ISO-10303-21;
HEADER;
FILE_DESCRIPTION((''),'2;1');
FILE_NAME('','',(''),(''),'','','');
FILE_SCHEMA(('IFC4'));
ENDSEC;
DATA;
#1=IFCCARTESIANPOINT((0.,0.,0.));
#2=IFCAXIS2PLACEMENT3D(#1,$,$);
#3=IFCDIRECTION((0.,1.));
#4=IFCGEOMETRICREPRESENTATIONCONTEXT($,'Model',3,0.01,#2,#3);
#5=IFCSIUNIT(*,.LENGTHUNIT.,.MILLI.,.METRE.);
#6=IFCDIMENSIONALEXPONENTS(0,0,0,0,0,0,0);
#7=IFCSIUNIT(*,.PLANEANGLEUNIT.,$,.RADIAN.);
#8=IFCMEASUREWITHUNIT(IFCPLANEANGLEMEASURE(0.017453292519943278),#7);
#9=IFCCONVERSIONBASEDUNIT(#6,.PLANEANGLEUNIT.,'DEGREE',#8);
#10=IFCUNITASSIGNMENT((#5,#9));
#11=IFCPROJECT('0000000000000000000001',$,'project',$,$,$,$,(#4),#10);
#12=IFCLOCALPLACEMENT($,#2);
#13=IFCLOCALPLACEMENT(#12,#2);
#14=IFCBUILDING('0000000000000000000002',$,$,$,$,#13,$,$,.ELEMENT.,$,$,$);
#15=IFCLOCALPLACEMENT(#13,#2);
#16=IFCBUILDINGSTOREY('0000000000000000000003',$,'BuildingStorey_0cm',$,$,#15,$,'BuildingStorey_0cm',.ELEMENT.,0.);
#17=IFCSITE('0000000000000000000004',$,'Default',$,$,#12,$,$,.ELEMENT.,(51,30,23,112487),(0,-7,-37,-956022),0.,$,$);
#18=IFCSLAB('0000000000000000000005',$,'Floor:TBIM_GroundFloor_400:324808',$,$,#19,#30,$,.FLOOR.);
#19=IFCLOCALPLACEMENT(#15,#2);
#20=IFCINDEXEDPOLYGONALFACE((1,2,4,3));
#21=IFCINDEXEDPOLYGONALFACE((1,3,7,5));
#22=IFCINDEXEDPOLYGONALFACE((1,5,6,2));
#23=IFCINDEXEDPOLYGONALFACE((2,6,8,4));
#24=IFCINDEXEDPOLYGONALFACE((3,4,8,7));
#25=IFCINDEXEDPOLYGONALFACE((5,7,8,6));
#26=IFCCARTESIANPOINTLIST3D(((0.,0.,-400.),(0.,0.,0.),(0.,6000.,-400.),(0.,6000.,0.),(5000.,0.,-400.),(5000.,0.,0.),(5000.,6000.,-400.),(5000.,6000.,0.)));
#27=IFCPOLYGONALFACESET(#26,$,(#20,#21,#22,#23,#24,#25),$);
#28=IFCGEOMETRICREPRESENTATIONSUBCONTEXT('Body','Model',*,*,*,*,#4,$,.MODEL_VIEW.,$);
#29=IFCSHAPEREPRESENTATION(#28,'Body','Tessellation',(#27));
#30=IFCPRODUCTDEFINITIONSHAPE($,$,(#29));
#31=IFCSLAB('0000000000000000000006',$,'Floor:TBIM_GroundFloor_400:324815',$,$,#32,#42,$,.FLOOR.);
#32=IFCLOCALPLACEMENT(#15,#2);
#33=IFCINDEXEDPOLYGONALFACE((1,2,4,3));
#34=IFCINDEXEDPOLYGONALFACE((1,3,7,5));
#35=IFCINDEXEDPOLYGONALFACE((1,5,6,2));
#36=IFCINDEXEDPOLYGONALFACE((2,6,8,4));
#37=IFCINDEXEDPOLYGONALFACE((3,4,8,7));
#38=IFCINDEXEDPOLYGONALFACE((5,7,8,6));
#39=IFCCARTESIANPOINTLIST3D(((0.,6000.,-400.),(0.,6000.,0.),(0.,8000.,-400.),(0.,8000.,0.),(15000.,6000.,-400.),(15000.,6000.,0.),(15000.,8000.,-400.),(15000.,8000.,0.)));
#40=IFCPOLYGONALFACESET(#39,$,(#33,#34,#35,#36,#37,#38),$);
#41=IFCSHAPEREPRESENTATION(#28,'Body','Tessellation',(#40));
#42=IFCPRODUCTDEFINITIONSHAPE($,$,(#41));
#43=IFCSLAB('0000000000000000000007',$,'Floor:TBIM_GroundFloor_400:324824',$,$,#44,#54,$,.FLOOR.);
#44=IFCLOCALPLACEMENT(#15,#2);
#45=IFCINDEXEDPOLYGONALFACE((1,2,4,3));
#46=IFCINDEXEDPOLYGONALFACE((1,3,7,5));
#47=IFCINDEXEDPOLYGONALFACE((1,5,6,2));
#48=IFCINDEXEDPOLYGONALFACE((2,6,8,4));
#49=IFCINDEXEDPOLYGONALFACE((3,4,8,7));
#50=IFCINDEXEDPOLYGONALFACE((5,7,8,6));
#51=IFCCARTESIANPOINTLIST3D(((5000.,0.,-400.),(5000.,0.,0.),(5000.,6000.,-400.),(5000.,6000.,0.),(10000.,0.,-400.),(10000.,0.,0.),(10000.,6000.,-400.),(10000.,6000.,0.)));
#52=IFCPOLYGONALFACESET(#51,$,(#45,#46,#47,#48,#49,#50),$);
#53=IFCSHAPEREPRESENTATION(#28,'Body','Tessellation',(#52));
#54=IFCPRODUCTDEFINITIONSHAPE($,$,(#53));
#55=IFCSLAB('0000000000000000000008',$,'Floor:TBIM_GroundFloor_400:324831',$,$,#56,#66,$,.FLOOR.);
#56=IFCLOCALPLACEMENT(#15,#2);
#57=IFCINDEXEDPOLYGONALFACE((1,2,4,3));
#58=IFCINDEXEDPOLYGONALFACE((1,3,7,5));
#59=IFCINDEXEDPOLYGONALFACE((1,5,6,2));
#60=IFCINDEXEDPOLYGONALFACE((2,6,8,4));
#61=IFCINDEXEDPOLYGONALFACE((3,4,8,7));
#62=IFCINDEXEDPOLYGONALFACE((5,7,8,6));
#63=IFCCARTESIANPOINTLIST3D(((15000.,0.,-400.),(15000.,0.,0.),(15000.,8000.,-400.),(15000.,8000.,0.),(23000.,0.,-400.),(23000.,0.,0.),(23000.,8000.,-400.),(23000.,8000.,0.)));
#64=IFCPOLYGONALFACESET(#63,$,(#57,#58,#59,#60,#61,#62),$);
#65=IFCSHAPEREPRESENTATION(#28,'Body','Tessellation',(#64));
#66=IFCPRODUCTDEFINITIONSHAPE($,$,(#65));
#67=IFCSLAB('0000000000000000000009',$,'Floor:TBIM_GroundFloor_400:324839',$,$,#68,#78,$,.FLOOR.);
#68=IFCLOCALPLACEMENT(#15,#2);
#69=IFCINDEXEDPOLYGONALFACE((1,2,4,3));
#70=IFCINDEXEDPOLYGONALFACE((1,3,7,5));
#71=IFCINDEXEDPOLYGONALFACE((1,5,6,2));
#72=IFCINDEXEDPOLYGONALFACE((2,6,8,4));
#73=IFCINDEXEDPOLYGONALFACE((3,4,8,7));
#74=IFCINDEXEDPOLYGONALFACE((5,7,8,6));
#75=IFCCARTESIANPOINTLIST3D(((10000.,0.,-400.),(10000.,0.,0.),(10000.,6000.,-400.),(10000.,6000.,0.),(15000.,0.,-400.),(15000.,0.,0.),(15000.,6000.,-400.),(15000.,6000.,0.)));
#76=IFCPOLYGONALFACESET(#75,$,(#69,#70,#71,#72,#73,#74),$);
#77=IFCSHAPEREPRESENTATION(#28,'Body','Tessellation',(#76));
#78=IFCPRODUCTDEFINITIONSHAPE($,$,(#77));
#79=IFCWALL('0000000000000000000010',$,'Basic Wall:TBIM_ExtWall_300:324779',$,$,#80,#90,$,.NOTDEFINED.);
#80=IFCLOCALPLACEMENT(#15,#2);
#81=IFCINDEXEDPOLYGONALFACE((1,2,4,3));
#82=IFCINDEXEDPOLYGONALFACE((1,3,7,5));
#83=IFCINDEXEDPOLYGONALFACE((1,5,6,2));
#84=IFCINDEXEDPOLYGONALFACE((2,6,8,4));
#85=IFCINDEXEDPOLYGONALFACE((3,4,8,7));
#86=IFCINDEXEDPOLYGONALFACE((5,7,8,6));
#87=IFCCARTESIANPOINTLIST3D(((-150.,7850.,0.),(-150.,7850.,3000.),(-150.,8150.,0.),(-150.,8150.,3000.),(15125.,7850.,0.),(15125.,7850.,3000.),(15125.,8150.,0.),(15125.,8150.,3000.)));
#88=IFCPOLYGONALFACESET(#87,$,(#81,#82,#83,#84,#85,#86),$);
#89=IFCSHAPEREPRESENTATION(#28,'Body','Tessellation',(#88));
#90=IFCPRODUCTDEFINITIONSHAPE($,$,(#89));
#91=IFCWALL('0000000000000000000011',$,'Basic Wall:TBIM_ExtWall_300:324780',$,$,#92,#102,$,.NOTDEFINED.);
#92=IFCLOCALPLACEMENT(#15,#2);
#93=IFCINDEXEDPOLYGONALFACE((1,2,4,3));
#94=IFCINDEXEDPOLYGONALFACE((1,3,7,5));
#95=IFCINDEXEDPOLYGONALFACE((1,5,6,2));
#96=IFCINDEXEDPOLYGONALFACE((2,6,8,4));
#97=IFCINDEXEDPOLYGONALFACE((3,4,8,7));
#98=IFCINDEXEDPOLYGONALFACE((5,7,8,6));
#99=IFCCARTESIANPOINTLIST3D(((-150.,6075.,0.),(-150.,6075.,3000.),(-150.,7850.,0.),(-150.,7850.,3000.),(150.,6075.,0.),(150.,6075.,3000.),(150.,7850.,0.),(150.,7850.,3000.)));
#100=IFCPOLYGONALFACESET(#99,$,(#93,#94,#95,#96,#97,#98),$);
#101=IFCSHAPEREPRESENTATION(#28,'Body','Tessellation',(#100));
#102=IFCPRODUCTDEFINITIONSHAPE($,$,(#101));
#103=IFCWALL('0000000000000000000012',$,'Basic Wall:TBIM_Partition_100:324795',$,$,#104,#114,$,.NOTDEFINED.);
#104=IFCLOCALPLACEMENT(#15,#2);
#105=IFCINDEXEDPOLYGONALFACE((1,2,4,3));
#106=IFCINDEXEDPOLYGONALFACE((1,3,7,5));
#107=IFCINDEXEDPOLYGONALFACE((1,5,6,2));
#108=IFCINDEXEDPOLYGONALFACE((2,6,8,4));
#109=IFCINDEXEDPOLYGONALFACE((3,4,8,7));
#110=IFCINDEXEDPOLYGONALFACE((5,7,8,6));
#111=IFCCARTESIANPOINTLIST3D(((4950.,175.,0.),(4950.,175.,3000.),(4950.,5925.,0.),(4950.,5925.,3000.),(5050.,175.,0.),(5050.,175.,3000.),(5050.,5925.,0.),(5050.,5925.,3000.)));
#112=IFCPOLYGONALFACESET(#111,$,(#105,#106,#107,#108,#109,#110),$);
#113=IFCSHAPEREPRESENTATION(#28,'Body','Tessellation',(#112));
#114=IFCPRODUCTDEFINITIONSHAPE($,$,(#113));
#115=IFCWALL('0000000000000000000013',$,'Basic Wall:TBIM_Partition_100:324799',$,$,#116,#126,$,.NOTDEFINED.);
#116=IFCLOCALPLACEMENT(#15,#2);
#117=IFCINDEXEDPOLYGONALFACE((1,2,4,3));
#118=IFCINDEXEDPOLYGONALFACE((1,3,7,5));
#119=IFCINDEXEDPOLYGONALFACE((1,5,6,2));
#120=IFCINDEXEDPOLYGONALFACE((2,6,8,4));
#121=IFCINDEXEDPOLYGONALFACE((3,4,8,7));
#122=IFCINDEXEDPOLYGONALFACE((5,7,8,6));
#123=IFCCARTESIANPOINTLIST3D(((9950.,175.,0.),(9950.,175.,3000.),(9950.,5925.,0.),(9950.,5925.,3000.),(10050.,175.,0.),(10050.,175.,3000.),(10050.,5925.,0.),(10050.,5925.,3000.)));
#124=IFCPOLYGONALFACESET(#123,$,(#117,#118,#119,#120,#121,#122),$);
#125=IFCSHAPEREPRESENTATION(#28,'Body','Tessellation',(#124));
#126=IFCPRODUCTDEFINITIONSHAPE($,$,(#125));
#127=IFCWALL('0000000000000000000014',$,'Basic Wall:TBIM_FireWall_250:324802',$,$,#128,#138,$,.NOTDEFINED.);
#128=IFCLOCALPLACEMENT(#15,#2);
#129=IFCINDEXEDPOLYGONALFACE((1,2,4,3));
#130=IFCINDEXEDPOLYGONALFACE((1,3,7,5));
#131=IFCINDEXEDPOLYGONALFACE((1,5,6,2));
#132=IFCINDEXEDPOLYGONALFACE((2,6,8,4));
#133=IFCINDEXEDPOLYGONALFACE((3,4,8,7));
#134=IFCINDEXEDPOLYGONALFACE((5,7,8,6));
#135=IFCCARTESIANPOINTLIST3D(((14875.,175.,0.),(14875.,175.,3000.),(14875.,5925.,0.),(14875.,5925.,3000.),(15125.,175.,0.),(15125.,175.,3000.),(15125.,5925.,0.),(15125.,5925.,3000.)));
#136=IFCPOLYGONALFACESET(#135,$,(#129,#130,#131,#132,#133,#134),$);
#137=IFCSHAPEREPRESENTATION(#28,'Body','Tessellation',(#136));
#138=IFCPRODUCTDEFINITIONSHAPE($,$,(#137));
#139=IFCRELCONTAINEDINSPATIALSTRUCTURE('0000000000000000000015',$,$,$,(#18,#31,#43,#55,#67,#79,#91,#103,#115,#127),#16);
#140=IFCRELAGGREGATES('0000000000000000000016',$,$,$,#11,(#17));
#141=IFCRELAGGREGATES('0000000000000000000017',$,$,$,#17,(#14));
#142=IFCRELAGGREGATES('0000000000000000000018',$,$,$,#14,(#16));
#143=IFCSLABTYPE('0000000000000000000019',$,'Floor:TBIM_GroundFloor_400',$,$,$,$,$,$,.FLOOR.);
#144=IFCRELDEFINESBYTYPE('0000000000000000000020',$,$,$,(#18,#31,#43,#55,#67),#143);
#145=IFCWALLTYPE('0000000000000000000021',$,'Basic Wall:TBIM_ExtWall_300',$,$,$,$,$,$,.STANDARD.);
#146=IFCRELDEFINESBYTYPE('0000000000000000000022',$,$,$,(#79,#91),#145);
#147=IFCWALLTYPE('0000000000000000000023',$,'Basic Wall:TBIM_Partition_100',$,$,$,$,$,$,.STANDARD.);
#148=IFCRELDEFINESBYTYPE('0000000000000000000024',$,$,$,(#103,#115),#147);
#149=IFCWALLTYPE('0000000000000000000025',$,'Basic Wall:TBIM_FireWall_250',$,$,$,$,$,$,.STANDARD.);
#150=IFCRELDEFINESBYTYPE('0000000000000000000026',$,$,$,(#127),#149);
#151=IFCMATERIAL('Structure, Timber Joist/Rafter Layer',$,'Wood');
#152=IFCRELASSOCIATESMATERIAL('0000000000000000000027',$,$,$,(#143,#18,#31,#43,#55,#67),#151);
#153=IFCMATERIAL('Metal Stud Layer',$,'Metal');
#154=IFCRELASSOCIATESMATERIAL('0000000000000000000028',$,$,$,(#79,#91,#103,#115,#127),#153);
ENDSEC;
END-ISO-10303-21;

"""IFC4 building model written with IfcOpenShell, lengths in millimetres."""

from ifc_helpers import new_model, entity, si_unit, converted_unit, direction, frame, origin, place, context, subcontext, project, spatial, indexed_curve, outline, extrude, material, type_object, element, save


model = new_model("IFC4")

# Units and contexts
model_context = context("Model", 3, precision=0.01, world=origin(), true_north=direction((0.0, 1.0)))
body_context = subcontext(model_context, "Body", "Model", "MODEL_VIEW")
ifc_project = project(units=[si_unit("LENGTHUNIT", "METRE", prefix="MILLI"), converted_unit("PLANEANGLEUNIT", "DEGREE", entity("IfcPlaneAngleMeasure", 0.017453292519943278), si_unit("PLANEANGLEUNIT", "RADIAN"), dimensions=[0, 0, 0, 0, 0, 0, 0])], contexts=[model_context])

# Site, building, storey
site_placement = place(None, origin())
site = spatial("IfcSite", under=ifc_project, at=site_placement, Name="Default", CompositionType="ELEMENT", RefLatitude=(51, 30, 23, 112487), RefLongitude=(0, -7, -37, -956022), RefElevation=0.0)
building_placement = place(site_placement, origin())
building = spatial("IfcBuilding", under=site, at=building_placement, CompositionType="ELEMENT")
storey_placement = place(building_placement, origin())
storey = spatial("IfcBuildingStorey", under=building, at=storey_placement, Name="BuildingStorey_0cm", LongName="BuildingStorey_0cm", CompositionType="ELEMENT", Elevation=0.0)

# Slabs
ifc_material_1 = material(Name="Structure, Timber Joist/Rafter Layer", Category="Wood")
slab_type = type_object("IfcSlabType", Name="Floor:TBIM_GroundFloor_400", PredefinedType="FLOOR", material=ifc_material_1)
slab_1_placement = place(storey_placement, origin())
element("IfcSlab", 1, at=slab_1_placement, inside=storey, type_object=slab_type, material=ifc_material_1, Name="Floor:TBIM_GroundFloor_400:324808", PredefinedType="FLOOR", context=body_context, shape_type="SweptSolid", body=[
    extrude(outline(indexed_curve([(-3000.0, -2500.0), (3000.0, -2500.0), (3000.0, 2500.0), (-3000.0, 2500.0), (-3000.0, -2500.0)], self_intersect=False)), frame((2500.0, 3000.0, 0.0), z_axis=(0.0, 0.0, -1.0), x_axis=(0.0, 1.0, 0.0)), (0.0, 0.0, 1.0), 400.0),
])
slab_2_placement = place(storey_placement, origin())
element("IfcSlab", 2, at=slab_2_placement, inside=storey, type_object=slab_type, material=ifc_material_1, Name="Floor:TBIM_GroundFloor_400:324815", PredefinedType="FLOOR", context=body_context, shape_type="SweptSolid", body=[
    extrude(outline(indexed_curve([(-1000.0, -7500.0), (1000.0, -7500.0), (1000.0, 7500.0), (-1000.0, 7500.0), (-1000.0, -7500.0)], self_intersect=False)), frame((7500.0, 7000.0, 0.0), z_axis=(0.0, 0.0, -1.0), x_axis=(0.0, 1.0, 0.0)), (0.0, 0.0, 1.0), 400.0),
])
slab_3_placement = place(storey_placement, origin())
element("IfcSlab", 3, at=slab_3_placement, inside=storey, type_object=slab_type, material=ifc_material_1, Name="Floor:TBIM_GroundFloor_400:324824", PredefinedType="FLOOR", context=body_context, shape_type="SweptSolid", body=[
    extrude(outline(indexed_curve([(-3000.0, -2500.0), (3000.0, -2500.0), (3000.0, 2500.0), (-3000.0, 2500.0), (-3000.0, -2500.0)], self_intersect=False)), frame((7500.0, 3000.0, 0.0), z_axis=(0.0, 0.0, -1.0), x_axis=(0.0, 1.0, 0.0)), (0.0, 0.0, 1.0), 400.0),
])
slab_4_placement = place(storey_placement, origin())
element("IfcSlab", 4, at=slab_4_placement, inside=storey, type_object=slab_type, material=ifc_material_1, Name="Floor:TBIM_GroundFloor_400:324831", PredefinedType="FLOOR", context=body_context, shape_type="SweptSolid", body=[
    extrude(outline(indexed_curve([(-4000.0, -4000.0), (4000.0, -4000.0), (4000.0, 4000.0), (-4000.0, 4000.0), (-4000.0, -4000.0)], self_intersect=False)), frame((19000.0, 4000.0, 0.0), z_axis=(0.0, 0.0, -1.0), x_axis=(1.0, 0.0, 0.0)), (0.0, 0.0, 1.0), 400.0),
])
slab_5_placement = place(storey_placement, origin())
element("IfcSlab", 5, at=slab_5_placement, inside=storey, type_object=slab_type, material=ifc_material_1, Name="Floor:TBIM_GroundFloor_400:324839", PredefinedType="FLOOR", context=body_context, shape_type="SweptSolid", body=[
    extrude(outline(indexed_curve([(-3000.0, -2500.0), (3000.0, -2500.0), (3000.0, 2500.0), (-3000.0, 2500.0), (-3000.0, -2500.0)], self_intersect=False)), frame((12500.0, 3000.0, 0.0), z_axis=(0.0, 0.0, -1.0), x_axis=(0.0, 1.0, 0.0)), (0.0, 0.0, 1.0), 400.0),
])

# Walls
ifc_material_2 = material(Name="Metal Stud Layer", Category="Metal")
wall_type_1 = type_object("IfcWallType", Name="Basic Wall:TBIM_ExtWall_300", PredefinedType="STANDARD")
wall_1_placement = place(storey_placement, frame((-150.0, 8000.0, 0.0)))
element("IfcWall", 6, at=wall_1_placement, inside=storey, type_object=wall_type_1, material=ifc_material_2, Name="Basic Wall:TBIM_ExtWall_300:324779", PredefinedType="NOTDEFINED", context=body_context, shape_type="SweptSolid", body=[
    extrude(outline(indexed_curve([(15275.0, 150.0), (0.0, 150.0), (0.0, -150.0), (15275.0, -150.0), (15275.0, 150.0)], self_intersect=False)), origin(), (0.0, 0.0, 1.0), 3000.0),
])
wall_2_placement = place(storey_placement, frame((0.0, 7850.0, 0.0), z_axis=(0.0, 0.0, 1.0), x_axis=(0.0, -1.0, 0.0)))
element("IfcWall", 7, at=wall_2_placement, inside=storey, type_object=wall_type_1, material=ifc_material_2, Name="Basic Wall:TBIM_ExtWall_300:324780", PredefinedType="NOTDEFINED", context=body_context, shape_type="SweptSolid", body=[
    extrude(outline(indexed_curve([(1775.0, 150.0), (0.0, 150.0), (0.0, -150.0), (1775.0, -150.0), (1775.0, 150.0)], self_intersect=False)), origin(), (0.0, 0.0, 1.0), 3000.0),
])
wall_type_2 = type_object("IfcWallType", Name="Basic Wall:TBIM_Partition_100", PredefinedType="STANDARD")
wall_3_placement = place(storey_placement, frame((5000.0, 175.0, 0.0), z_axis=(0.0, 0.0, 1.0), x_axis=(0.0, 1.0, 0.0)))
element("IfcWall", 8, at=wall_3_placement, inside=storey, type_object=wall_type_2, material=ifc_material_2, Name="Basic Wall:TBIM_Partition_100:324795", PredefinedType="NOTDEFINED", context=body_context, shape_type="SweptSolid", body=[
    extrude(outline(indexed_curve([(5750.0, 50.0), (0.0, 50.0), (0.0, -50.0), (5750.0, -50.0), (5750.0, 50.0)], self_intersect=False)), origin(), (0.0, 0.0, 1.0), 3000.0),
])
wall_4_placement = place(storey_placement, frame((10000.0, 175.0, 0.0), z_axis=(0.0, 0.0, 1.0), x_axis=(0.0, 1.0, 0.0)))
element("IfcWall", 9, at=wall_4_placement, inside=storey, type_object=wall_type_2, material=ifc_material_2, Name="Basic Wall:TBIM_Partition_100:324799", PredefinedType="NOTDEFINED", context=body_context, shape_type="SweptSolid", body=[
    extrude(outline(indexed_curve([(5750.0, 50.0), (0.0, 50.0), (0.0, -50.0), (5750.0, -50.0), (5750.0, 50.0)], self_intersect=False)), origin(), (0.0, 0.0, 1.0), 3000.0),
])
wall_type_3 = type_object("IfcWallType", Name="Basic Wall:TBIM_FireWall_250", PredefinedType="STANDARD")
wall_5_placement = place(storey_placement, frame((15000.0, 175.0, 0.0), z_axis=(0.0, 0.0, 1.0), x_axis=(0.0, 1.0, 0.0)))
element("IfcWall", 10, at=wall_5_placement, inside=storey, type_object=wall_type_3, material=ifc_material_2, Name="Basic Wall:TBIM_FireWall_250:324802", PredefinedType="NOTDEFINED", context=body_context, shape_type="SweptSolid", body=[
    extrude(outline(indexed_curve([(5750.0, 125.0), (0.0, 125.0), (0.0, -125.0), (5750.0, -125.0), (5750.0, 125.0)], self_intersect=False)), origin(), (0.0, 0.0, 1.0), 3000.0),
])

save(model, "model.ifc")
